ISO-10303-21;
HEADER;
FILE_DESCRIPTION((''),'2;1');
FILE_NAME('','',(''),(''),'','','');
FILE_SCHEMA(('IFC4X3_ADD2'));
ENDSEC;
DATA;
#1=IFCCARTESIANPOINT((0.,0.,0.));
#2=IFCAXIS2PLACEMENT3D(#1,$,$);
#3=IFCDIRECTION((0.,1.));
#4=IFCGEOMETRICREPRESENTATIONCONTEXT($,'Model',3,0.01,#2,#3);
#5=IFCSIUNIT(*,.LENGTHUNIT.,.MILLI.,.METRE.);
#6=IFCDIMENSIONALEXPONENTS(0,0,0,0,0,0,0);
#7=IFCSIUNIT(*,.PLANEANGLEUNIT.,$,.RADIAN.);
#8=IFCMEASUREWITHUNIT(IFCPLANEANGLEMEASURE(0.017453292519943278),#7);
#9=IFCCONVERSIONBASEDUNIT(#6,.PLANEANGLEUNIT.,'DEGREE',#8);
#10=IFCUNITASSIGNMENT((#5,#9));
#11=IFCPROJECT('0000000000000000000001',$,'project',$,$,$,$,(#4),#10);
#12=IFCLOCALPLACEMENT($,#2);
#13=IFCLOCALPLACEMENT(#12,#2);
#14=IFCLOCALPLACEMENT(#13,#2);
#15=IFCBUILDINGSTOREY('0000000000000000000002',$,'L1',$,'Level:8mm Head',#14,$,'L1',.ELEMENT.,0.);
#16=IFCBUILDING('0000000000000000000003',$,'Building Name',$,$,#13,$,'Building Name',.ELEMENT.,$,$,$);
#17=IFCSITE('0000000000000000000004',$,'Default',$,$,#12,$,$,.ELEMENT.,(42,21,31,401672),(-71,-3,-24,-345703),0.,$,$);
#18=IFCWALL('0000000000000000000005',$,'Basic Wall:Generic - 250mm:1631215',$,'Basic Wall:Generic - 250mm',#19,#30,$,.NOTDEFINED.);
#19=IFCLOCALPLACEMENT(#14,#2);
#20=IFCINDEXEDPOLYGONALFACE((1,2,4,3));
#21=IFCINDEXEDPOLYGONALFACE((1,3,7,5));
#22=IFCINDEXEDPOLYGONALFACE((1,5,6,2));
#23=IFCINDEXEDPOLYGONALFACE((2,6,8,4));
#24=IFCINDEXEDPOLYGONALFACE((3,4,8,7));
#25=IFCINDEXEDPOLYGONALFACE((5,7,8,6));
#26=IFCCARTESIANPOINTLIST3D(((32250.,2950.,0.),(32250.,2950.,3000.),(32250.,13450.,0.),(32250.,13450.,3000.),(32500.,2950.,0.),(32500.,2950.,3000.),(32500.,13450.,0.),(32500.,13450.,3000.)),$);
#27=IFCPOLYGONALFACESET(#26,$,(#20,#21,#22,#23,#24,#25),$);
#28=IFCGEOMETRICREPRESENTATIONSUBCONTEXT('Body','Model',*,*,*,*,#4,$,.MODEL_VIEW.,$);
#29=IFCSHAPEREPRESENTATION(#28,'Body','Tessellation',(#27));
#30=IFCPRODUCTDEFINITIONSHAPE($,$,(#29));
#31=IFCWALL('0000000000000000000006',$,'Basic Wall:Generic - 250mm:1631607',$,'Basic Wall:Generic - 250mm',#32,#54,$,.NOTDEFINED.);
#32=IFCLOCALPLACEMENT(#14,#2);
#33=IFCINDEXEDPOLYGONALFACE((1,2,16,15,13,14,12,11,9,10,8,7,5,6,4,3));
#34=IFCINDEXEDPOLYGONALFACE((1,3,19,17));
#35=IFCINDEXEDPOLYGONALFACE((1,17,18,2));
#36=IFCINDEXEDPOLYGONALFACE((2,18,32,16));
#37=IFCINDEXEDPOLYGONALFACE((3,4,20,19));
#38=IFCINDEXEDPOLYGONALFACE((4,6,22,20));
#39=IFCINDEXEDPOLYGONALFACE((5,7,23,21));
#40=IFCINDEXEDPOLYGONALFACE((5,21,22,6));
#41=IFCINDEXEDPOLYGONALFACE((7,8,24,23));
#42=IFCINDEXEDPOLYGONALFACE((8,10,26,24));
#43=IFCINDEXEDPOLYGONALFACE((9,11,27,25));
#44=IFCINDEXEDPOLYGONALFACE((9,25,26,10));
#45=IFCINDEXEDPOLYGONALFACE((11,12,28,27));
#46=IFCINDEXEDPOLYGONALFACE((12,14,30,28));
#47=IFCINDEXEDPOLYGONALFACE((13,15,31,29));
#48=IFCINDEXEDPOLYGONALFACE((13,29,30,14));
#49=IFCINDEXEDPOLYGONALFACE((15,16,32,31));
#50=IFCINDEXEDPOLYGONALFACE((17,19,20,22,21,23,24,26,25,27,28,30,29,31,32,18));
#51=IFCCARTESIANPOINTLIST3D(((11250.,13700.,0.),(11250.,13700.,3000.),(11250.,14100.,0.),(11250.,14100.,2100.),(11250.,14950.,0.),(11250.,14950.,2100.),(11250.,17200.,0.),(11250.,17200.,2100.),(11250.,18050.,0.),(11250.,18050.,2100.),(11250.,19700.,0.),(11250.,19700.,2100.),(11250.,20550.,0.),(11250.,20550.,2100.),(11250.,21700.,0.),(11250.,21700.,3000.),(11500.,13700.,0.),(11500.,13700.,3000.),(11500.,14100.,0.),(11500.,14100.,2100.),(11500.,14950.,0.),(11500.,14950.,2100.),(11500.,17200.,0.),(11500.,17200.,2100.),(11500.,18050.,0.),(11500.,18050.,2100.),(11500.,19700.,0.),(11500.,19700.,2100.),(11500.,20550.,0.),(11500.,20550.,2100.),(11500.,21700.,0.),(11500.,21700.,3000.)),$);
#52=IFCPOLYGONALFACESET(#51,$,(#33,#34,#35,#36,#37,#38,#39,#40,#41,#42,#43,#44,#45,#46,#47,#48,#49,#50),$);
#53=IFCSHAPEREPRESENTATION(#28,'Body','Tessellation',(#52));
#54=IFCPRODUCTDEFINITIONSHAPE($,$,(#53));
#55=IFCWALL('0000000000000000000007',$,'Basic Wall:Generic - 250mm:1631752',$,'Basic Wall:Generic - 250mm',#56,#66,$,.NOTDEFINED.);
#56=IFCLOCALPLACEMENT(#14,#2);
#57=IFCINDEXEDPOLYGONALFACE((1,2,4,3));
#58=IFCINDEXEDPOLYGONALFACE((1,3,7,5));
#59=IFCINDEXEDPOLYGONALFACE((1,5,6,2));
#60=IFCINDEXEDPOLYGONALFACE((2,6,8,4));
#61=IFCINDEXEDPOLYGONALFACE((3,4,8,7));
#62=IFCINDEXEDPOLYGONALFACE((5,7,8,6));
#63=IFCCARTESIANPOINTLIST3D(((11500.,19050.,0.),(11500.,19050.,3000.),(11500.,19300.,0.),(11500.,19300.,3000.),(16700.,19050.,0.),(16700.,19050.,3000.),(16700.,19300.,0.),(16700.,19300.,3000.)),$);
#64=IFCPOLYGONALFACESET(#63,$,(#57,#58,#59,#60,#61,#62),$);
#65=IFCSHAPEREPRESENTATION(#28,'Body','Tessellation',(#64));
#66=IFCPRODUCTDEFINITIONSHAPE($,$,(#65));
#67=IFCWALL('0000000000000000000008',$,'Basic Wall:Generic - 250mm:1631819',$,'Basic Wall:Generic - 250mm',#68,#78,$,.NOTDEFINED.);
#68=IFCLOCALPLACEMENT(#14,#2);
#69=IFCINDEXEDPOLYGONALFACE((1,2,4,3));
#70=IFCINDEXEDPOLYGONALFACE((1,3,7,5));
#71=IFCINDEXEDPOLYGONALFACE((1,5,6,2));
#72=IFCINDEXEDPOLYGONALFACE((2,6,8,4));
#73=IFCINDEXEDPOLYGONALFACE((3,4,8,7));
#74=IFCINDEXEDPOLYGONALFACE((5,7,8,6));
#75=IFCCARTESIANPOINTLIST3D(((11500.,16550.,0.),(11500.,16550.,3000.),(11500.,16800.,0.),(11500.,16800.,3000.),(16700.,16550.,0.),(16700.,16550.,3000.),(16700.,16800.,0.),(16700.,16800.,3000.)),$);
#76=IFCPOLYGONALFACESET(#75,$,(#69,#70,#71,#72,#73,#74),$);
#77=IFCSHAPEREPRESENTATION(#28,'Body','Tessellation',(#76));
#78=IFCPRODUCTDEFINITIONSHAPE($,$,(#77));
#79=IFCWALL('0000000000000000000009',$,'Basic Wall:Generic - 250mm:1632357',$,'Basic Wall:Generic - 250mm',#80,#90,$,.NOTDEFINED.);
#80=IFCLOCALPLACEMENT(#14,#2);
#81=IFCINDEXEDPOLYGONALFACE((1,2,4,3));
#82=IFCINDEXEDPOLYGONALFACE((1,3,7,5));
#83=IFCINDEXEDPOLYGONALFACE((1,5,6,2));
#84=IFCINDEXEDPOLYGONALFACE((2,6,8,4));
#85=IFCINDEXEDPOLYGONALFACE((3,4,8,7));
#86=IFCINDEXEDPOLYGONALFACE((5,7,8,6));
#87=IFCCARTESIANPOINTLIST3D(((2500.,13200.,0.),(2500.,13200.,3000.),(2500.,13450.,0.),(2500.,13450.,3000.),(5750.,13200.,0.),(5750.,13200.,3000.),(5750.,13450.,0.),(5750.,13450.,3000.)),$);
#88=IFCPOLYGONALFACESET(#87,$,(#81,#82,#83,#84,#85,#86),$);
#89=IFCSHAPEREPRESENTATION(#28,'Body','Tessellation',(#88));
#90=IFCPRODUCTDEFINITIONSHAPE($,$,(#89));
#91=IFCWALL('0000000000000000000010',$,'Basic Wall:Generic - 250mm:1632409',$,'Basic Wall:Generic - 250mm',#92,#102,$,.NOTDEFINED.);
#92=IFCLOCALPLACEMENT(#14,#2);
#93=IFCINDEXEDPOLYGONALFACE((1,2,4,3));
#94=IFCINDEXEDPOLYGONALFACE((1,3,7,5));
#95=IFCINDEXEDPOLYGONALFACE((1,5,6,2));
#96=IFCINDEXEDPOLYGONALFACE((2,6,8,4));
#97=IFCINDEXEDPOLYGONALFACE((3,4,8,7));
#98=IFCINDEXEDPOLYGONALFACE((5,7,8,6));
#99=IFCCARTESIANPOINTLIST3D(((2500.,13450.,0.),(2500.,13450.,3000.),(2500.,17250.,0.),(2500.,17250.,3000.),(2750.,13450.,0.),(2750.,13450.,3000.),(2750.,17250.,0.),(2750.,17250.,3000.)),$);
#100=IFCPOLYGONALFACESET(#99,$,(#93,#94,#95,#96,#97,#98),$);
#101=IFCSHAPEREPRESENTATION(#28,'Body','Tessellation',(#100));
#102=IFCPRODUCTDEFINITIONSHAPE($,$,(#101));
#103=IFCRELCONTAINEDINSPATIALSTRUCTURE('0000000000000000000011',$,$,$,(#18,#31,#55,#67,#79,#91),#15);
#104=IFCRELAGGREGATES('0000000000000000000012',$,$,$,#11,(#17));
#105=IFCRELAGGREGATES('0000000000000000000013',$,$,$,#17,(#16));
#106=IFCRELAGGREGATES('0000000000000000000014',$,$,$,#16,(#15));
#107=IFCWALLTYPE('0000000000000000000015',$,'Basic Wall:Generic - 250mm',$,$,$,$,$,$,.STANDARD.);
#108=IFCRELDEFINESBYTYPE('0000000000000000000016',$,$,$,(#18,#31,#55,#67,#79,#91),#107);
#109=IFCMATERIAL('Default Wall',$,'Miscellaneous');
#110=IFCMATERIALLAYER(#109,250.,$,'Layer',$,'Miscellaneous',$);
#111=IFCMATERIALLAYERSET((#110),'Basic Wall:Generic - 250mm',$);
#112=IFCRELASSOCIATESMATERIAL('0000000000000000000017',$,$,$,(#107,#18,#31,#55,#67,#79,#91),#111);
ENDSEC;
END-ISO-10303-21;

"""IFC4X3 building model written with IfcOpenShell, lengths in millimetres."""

from ifc_helpers import new_model, entity, si_unit, converted_unit, direction, frame, frame_2d, origin, place, context, subcontext, project, spatial, rectangle, extrude, material, layer, layer_set, type_object, element, save


model = new_model("IFC4X3")

# Units and contexts
model_context = context("Model", 3, precision=0.01, world=origin(), true_north=direction((0.0, 1.0)))
body_context = subcontext(model_context, "Body", "Model", "MODEL_VIEW")
ifc_project = project(units=[si_unit("LENGTHUNIT", "METRE", prefix="MILLI"), converted_unit("PLANEANGLEUNIT", "DEGREE", entity("IfcPlaneAngleMeasure", 0.017453292519943278), si_unit("PLANEANGLEUNIT", "RADIAN"), dimensions=[0, 0, 0, 0, 0, 0, 0])], contexts=[model_context])

# Site, building, storey
site_placement = place(None, origin())
site = spatial("IfcSite", under=ifc_project, at=site_placement, Name="Default", CompositionType="ELEMENT", RefLatitude=(42, 21, 31, 401672), RefLongitude=(-71, -3, -24, -345703), RefElevation=0.0)
building_placement = place(site_placement, origin())
building = spatial("IfcBuilding", under=site, at=building_placement, Name="Building Name", LongName="Building Name", CompositionType="ELEMENT")
storey_placement = place(building_placement, origin())
storey = spatial("IfcBuildingStorey", under=building, at=storey_placement, Name="L1", ObjectType="Level:8mm Head", LongName="L1", CompositionType="ELEMENT", Elevation=0.0)

# Shared definitions
ifc_material = material(Name="Default Wall", Category="Miscellaneous")
ifc_layer = layer(ifc_material, 250.0, Name="Layer", Category="Miscellaneous")
ifc_layer_set = layer_set([ifc_layer], Name="Basic Wall:Generic - 250mm")
wall_type = type_object("IfcWallType", Name="Basic Wall:Generic - 250mm", PredefinedType="STANDARD", material=ifc_layer_set)

# Wall
wall_1_placement = place(storey_placement, frame((32375.0, 2950.0, 0.0), z_axis=(0.0, 0.0, 1.0), x_axis=(0.0, 1.0, 0.0)))
element("IfcWall", 1, at=wall_1_placement, inside=storey, type_object=wall_type, material=ifc_layer_set, Name="Basic Wall:Generic - 250mm:1631215", ObjectType="Basic Wall:Generic - 250mm", PredefinedType="NOTDEFINED", context=body_context, shape_type="SweptSolid", body=[
    extrude(rectangle(XDim=10500.0, YDim=250.0, at=frame_2d((5250.0, 0.0), x_axis=(-1.0, 0.0))), origin(), (0.0, 0.0, 1.0), 3000.0),
])

# Wall, openings
wall_2_placement = place(storey_placement, frame((11375.0, 13700.0, 0.0), z_axis=(0.0, 0.0, 1.0), x_axis=(0.0, 1.0, 0.0)))
wall_2 = element("IfcWall", 2, at=wall_2_placement, inside=storey, type_object=wall_type, material=ifc_layer_set, Name="Basic Wall:Generic - 250mm:1631607", ObjectType="Basic Wall:Generic - 250mm", PredefinedType="NOTDEFINED", context=body_context, shape_type="SweptSolid", body=[
    extrude(rectangle(XDim=8000.0, YDim=250.0, at=frame_2d((4000.0, 0.0), x_axis=(-1.0, 0.0))), origin(), (0.0, 0.0, 1.0), 3000.0),
])
opening_1_placement = place(wall_2_placement, frame((6850.0, 125.0, 0.0)))
element("IfcOpeningElement", 3, at=opening_1_placement, cuts=wall_2, PredefinedType="OPENING", context=body_context, shape_type="SweptSolid", body=[
    extrude(rectangle(XDim=2100.0, YDim=850.0, at=frame_2d((1050.0, 425.0), x_axis=(1.0, 0.0))), frame((0.0, 0.0, 0.0), z_axis=(0.0, -1.0, 0.0), x_axis=(0.0, 0.0, 1.0)), (0.0, 0.0, 1.0), 250.0),
])
opening_2_placement = place(wall_2_placement, frame((4350.0, 125.0, 0.0)))
element("IfcOpeningElement", 4, at=opening_2_placement, cuts=wall_2, PredefinedType="OPENING", context=body_context, shape_type="SweptSolid", body=[
    extrude(rectangle(XDim=2100.0, YDim=850.0, at=frame_2d((1050.0, 425.0), x_axis=(1.0, 0.0))), frame((0.0, 0.0, 0.0), z_axis=(0.0, -1.0, 0.0), x_axis=(0.0, 0.0, 1.0)), (0.0, 0.0, 1.0), 250.0),
])
opening_3_placement = place(wall_2_placement, frame((1250.0, 125.0, 0.0)))
element("IfcOpeningElement", 5, at=opening_3_placement, cuts=wall_2, PredefinedType="OPENING", context=body_context, shape_type="SweptSolid", body=[
    extrude(rectangle(XDim=2100.0, YDim=850.0, at=frame_2d((1050.0, 425.0), x_axis=(1.0, 0.0))), frame((0.0, 0.0, 0.0), z_axis=(0.0, -1.0, 0.0), x_axis=(0.0, 0.0, 1.0)), (0.0, 0.0, 1.0), 250.0),
])

# Walls
wall_3_placement = place(storey_placement, frame((11500.0, 19175.0, 0.0)))
element("IfcWall", 6, at=wall_3_placement, inside=storey, type_object=wall_type, material=ifc_layer_set, Name="Basic Wall:Generic - 250mm:1631752", ObjectType="Basic Wall:Generic - 250mm", PredefinedType="NOTDEFINED", context=body_context, shape_type="SweptSolid", body=[
    extrude(rectangle(XDim=5200.0, YDim=250.0, at=frame_2d((2600.0, 0.0), x_axis=(-1.0, 0.0))), origin(), (0.0, 0.0, 1.0), 3000.0),
])
wall_4_placement = place(storey_placement, frame((11500.0, 16675.0, 0.0)))
element("IfcWall", 7, at=wall_4_placement, inside=storey, type_object=wall_type, material=ifc_layer_set, Name="Basic Wall:Generic - 250mm:1631819", ObjectType="Basic Wall:Generic - 250mm", PredefinedType="NOTDEFINED", context=body_context, shape_type="SweptSolid", body=[
    extrude(rectangle(XDim=5200.0, YDim=250.0, at=frame_2d((2600.0, 0.0), x_axis=(-1.0, 0.0))), origin(), (0.0, 0.0, 1.0), 3000.0),
])
wall_5_placement = place(storey_placement, frame((5750.0, 13325.0, 0.0), z_axis=(0.0, 0.0, 1.0), x_axis=(-1.0, 0.0, 0.0)))
element("IfcWall", 8, at=wall_5_placement, inside=storey, type_object=wall_type, material=ifc_layer_set, Name="Basic Wall:Generic - 250mm:1632357", ObjectType="Basic Wall:Generic - 250mm", PredefinedType="NOTDEFINED", context=body_context, shape_type="SweptSolid", body=[
    extrude(rectangle(XDim=3250.0, YDim=250.0, at=frame_2d((1625.0, 0.0), x_axis=(-1.0, 0.0))), origin(), (0.0, 0.0, 1.0), 3000.0),
])
wall_6_placement = place(storey_placement, frame((2625.0, 13450.0, 0.0), z_axis=(0.0, 0.0, 1.0), x_axis=(0.0, 1.0, 0.0)))
element("IfcWall", 9, at=wall_6_placement, inside=storey, type_object=wall_type, material=ifc_layer_set, Name="Basic Wall:Generic - 250mm:1632409", ObjectType="Basic Wall:Generic - 250mm", PredefinedType="NOTDEFINED", context=body_context, shape_type="SweptSolid", body=[
    extrude(rectangle(XDim=3800.0, YDim=250.0, at=frame_2d((1900.0, 0.0), x_axis=(-1.0, 0.0))), origin(), (0.0, 0.0, 1.0), 3000.0),
])

save(model, "model.ifc")
